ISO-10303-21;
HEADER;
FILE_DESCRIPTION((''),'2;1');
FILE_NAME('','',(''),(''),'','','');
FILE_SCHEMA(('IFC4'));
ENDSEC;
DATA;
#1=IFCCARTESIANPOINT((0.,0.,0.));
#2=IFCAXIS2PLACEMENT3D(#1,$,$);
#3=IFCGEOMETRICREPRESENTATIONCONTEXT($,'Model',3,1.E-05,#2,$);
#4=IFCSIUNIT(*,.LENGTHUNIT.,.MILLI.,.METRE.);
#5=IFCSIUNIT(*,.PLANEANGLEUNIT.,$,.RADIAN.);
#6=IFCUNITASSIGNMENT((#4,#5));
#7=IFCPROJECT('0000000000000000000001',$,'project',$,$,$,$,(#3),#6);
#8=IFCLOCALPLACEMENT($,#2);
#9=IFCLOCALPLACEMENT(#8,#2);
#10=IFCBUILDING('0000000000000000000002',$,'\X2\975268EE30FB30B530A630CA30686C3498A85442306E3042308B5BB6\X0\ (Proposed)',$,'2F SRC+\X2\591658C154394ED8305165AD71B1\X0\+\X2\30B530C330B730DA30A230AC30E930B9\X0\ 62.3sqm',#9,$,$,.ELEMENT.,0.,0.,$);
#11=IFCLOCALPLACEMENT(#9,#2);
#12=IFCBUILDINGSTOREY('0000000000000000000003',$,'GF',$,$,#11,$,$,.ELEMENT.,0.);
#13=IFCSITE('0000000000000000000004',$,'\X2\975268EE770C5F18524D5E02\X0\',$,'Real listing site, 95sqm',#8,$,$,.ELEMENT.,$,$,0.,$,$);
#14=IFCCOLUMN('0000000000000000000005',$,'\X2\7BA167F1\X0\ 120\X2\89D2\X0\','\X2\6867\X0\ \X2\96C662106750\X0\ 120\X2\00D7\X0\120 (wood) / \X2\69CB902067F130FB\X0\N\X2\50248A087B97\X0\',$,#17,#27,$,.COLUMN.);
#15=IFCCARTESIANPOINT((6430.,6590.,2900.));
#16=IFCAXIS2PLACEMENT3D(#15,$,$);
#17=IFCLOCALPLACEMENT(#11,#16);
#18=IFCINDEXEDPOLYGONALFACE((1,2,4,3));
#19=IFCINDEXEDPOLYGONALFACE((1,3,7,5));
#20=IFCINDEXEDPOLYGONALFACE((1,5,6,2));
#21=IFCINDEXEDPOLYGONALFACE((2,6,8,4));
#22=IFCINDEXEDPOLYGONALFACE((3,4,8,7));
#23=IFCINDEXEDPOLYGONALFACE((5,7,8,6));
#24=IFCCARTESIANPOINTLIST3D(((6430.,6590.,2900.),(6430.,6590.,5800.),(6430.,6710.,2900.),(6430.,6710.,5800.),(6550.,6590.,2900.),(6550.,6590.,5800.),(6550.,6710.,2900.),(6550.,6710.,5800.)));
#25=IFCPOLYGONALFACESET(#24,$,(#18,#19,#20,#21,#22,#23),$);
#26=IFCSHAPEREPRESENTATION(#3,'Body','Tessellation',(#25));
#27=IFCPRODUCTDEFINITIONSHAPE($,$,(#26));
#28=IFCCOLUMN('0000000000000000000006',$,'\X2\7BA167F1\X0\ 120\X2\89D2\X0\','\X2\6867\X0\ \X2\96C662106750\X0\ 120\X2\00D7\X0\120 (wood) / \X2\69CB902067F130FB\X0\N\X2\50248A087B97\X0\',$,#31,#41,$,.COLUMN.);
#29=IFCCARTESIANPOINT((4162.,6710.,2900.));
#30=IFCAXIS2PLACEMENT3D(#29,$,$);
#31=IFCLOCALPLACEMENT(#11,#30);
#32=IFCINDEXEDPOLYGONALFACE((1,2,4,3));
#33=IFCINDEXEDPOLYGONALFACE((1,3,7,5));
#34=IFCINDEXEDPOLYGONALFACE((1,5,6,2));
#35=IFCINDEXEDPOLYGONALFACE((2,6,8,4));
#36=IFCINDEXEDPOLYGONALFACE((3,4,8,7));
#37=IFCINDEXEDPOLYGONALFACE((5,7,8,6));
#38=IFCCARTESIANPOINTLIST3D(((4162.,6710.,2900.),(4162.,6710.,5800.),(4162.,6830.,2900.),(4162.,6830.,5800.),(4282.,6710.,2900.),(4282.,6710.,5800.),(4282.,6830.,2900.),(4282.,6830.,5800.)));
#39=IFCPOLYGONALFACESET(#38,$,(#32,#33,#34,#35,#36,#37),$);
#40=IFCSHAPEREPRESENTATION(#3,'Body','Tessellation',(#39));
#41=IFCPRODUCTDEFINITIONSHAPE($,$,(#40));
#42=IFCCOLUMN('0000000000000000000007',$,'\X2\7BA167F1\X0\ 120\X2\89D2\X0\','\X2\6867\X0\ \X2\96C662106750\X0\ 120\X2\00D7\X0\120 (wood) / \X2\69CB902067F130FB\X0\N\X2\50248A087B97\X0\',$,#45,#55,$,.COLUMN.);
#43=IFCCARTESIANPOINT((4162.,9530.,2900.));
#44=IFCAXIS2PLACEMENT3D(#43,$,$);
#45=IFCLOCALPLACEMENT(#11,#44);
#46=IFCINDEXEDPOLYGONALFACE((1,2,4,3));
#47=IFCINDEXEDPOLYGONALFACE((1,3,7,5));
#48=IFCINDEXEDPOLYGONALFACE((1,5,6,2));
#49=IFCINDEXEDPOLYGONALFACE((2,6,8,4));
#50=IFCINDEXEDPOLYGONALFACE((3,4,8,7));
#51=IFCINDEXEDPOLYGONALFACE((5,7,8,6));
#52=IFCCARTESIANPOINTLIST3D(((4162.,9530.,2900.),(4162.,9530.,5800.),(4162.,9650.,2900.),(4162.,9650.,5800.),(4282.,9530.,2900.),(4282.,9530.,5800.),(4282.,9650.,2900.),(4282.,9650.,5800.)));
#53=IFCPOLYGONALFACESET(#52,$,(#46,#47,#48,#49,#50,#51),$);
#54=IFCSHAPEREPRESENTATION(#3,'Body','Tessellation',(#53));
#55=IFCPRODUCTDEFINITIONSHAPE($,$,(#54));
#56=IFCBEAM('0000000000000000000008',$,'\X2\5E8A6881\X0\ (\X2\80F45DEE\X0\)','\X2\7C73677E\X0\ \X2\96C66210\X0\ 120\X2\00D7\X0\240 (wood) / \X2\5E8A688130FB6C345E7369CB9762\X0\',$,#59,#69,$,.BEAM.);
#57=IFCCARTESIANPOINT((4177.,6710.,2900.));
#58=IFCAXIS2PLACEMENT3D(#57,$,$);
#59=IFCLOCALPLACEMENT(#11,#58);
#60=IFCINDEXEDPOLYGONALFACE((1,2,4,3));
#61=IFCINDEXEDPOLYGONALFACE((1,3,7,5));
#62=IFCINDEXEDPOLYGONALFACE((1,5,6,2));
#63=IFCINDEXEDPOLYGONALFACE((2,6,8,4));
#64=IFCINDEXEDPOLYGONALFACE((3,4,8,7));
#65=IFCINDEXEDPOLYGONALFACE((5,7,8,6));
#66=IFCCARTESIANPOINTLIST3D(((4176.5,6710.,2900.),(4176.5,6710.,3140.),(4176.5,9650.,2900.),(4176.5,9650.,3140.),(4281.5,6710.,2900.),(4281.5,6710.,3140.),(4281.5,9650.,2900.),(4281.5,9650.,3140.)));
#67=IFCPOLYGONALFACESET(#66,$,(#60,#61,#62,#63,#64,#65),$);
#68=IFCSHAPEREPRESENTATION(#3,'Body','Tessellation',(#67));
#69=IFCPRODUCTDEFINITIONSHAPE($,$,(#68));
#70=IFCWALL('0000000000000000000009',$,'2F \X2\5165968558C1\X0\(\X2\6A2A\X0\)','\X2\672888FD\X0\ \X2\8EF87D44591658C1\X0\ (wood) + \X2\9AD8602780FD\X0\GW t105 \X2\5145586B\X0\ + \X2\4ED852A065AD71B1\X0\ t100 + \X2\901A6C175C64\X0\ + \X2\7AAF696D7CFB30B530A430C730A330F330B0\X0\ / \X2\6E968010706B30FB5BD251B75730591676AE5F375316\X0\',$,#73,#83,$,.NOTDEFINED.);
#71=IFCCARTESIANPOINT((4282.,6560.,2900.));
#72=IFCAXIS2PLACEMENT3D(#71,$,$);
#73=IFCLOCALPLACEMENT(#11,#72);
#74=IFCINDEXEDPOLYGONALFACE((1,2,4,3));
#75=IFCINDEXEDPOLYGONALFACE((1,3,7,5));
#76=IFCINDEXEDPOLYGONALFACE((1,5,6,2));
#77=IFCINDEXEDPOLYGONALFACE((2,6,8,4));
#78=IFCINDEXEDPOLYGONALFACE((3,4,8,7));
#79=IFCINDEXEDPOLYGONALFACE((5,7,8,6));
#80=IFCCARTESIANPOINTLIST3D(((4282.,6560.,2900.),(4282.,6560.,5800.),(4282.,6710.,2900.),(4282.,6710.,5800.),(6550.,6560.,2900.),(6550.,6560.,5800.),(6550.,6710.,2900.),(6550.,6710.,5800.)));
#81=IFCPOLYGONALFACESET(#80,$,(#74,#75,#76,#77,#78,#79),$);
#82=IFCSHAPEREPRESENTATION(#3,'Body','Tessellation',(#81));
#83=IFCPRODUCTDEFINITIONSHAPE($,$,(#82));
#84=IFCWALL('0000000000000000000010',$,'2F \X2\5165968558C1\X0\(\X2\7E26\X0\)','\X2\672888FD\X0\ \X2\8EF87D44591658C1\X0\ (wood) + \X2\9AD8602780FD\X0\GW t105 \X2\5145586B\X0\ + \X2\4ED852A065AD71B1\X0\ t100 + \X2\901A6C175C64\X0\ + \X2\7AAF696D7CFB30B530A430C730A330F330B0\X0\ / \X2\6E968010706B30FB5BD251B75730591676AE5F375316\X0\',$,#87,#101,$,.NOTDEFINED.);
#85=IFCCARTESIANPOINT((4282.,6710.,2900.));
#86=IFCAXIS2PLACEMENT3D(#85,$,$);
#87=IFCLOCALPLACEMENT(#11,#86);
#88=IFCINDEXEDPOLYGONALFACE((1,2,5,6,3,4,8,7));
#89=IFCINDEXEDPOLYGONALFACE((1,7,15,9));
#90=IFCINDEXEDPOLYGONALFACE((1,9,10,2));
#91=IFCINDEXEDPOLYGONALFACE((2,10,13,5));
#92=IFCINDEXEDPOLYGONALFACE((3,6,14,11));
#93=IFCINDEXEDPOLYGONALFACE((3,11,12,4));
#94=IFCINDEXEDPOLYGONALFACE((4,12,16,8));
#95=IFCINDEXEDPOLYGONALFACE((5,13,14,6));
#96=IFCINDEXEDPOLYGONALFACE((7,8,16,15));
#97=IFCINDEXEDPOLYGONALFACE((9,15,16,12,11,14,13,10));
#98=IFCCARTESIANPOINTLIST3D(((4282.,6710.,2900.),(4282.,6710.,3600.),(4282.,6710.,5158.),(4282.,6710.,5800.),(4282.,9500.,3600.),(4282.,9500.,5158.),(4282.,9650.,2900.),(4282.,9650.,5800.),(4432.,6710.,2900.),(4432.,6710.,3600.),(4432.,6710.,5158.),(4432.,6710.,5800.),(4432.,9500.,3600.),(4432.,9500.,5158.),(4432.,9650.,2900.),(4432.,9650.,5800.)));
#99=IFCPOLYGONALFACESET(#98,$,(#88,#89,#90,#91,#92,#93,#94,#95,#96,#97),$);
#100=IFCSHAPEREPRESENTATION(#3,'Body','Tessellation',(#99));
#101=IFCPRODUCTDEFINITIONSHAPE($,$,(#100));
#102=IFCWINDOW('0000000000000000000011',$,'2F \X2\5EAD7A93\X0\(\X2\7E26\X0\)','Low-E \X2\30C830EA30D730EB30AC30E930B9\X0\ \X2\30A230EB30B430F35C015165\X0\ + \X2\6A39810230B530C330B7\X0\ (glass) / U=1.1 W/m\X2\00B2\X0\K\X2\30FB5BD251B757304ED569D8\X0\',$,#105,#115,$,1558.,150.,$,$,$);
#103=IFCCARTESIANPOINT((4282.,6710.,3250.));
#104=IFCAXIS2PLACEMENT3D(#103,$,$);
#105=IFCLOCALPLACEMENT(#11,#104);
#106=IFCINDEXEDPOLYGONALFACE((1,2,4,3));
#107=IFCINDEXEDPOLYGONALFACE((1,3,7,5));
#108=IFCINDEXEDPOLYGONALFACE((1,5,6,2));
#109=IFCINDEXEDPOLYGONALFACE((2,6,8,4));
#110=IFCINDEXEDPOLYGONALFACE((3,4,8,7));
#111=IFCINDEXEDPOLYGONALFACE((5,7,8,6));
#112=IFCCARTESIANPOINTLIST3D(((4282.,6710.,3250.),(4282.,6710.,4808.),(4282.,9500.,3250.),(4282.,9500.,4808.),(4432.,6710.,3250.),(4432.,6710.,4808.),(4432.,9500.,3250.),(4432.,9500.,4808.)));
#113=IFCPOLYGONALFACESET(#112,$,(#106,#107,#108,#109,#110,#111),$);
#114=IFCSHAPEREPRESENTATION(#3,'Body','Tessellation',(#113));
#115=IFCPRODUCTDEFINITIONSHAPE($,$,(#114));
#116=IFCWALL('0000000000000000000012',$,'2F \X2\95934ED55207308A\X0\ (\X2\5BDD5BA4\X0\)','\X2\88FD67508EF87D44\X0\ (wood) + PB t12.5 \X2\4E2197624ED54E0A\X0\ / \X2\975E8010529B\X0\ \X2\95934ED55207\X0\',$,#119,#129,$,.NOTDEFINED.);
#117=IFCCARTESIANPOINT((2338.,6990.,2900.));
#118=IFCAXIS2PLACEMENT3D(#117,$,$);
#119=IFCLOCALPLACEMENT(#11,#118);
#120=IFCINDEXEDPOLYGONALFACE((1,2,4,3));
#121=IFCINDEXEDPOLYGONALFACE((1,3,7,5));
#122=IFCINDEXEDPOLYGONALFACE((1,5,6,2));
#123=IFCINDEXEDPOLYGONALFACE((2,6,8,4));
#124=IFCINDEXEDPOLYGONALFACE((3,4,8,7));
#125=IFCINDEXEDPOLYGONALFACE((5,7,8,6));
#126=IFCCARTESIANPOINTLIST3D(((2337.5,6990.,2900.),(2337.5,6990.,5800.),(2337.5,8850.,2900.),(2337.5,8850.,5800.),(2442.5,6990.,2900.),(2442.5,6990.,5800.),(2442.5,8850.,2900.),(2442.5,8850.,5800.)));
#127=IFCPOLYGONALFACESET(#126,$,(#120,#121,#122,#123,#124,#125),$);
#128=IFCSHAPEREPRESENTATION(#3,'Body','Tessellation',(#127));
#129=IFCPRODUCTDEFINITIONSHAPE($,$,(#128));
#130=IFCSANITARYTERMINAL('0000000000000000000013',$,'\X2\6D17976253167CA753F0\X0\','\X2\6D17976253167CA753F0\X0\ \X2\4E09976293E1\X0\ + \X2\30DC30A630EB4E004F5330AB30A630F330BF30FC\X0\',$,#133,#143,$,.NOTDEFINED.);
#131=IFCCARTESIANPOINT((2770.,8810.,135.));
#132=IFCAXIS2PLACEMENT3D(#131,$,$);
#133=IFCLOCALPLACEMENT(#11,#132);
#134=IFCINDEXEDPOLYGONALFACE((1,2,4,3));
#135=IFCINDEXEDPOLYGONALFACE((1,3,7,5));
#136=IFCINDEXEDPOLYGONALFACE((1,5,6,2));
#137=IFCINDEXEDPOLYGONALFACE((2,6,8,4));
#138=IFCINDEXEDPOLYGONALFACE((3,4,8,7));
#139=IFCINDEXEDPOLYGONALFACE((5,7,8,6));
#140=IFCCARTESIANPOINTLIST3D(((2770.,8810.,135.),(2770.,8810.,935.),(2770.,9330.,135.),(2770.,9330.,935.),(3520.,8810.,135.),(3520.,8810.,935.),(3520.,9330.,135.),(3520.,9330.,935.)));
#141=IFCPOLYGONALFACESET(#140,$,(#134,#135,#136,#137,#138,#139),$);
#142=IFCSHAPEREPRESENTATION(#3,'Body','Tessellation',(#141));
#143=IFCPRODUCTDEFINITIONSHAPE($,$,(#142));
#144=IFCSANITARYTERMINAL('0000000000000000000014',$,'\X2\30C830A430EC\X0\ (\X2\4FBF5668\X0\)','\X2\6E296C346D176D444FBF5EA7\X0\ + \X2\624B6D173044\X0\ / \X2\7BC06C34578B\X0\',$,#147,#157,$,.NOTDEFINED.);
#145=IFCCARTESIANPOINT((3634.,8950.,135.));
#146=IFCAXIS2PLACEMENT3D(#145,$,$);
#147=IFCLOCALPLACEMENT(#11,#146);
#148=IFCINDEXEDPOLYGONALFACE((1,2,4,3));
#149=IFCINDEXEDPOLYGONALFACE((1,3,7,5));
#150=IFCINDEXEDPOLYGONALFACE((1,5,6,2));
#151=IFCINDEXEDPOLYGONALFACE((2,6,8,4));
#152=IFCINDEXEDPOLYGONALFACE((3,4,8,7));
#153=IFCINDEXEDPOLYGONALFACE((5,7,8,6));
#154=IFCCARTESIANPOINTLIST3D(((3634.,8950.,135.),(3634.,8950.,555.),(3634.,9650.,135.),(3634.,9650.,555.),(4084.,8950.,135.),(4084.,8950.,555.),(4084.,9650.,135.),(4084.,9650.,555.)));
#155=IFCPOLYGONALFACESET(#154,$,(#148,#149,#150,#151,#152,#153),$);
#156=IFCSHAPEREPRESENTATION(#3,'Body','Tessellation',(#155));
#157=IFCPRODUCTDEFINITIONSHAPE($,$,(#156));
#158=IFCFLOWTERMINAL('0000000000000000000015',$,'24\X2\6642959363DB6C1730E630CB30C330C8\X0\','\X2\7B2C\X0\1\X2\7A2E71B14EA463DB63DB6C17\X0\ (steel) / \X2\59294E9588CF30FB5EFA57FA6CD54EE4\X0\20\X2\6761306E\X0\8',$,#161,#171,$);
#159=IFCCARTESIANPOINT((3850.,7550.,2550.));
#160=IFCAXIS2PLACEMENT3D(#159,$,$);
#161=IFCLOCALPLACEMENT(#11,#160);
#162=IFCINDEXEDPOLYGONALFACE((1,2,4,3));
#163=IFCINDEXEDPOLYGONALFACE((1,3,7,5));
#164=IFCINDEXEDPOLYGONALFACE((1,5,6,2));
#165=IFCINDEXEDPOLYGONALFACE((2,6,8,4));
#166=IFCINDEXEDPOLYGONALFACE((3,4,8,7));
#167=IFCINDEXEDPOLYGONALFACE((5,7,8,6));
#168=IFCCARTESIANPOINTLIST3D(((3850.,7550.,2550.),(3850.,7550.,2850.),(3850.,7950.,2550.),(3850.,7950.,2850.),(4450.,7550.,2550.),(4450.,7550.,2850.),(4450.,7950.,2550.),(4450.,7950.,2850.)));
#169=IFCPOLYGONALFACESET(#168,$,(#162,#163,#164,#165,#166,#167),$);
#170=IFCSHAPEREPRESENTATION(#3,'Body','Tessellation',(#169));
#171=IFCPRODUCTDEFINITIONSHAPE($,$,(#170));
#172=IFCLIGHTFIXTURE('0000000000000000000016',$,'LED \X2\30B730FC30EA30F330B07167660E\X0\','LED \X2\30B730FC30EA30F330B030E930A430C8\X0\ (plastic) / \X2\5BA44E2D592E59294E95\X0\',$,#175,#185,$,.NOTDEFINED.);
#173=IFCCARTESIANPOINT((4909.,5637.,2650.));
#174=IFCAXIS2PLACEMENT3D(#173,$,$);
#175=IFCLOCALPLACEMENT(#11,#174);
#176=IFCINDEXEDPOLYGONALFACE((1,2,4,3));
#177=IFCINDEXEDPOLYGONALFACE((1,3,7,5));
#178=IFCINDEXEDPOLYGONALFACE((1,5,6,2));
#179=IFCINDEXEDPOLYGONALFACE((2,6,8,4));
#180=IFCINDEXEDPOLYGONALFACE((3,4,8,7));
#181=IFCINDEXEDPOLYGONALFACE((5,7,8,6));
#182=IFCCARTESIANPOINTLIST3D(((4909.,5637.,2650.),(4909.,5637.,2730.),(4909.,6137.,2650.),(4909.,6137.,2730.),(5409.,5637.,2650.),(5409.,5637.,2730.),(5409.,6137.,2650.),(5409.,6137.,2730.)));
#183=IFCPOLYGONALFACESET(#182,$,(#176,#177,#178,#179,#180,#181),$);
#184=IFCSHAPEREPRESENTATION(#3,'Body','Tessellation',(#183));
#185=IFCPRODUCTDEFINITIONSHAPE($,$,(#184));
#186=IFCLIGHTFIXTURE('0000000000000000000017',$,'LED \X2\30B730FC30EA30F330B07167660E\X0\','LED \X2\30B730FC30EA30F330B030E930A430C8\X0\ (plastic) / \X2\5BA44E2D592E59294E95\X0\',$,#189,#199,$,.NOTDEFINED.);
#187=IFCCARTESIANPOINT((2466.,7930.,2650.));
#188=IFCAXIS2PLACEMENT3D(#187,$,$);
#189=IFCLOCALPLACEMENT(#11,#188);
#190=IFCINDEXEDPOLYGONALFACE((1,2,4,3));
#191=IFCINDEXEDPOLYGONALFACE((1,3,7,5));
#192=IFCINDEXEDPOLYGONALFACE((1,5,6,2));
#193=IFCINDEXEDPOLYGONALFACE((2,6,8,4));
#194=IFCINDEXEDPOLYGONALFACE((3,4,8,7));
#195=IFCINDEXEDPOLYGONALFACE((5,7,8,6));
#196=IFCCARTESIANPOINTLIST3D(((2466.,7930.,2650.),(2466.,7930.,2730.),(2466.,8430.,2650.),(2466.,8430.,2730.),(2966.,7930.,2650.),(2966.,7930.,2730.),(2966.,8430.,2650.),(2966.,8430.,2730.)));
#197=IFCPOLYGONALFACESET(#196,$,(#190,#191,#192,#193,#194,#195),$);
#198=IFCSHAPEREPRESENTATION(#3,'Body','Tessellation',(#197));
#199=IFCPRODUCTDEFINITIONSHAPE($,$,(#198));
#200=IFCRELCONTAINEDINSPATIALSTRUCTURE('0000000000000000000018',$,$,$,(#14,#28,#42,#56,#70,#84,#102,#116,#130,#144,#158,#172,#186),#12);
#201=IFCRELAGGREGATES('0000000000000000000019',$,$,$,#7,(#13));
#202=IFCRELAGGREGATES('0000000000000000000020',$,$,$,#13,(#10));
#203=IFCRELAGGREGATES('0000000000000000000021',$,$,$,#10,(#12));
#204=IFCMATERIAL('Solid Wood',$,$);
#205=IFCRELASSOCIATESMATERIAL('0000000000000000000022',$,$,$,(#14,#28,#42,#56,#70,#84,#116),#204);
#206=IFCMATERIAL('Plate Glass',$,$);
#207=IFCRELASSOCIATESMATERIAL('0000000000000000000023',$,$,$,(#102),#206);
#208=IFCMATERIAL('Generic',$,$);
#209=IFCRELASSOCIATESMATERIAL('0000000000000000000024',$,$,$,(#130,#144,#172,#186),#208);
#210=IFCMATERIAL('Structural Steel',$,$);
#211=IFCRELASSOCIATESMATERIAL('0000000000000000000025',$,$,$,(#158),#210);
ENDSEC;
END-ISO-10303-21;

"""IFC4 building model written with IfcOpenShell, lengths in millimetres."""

from ifc_helpers import new_model, si_unit, frame, frame_2d, origin, place, context, project, spatial, rectangle, extrude, material, element, fill, save


model = new_model("IFC4")

# Units and contexts
model_context = context("Model", 3, precision=1e-05, world=origin())
ifc_project = project(units=[si_unit("LENGTHUNIT", "METRE", prefix="MILLI"), si_unit("PLANEANGLEUNIT", "RADIAN")], contexts=[model_context])

# Site, building, storey
site_placement = place(None, origin())
site = spatial("IfcSite", under=ifc_project, at=site_placement, Name="青森県弘前市", ObjectType="Real listing site, 95sqm", CompositionType="ELEMENT", RefElevation=0.0)
building_placement = place(site_placement, origin())
building = spatial("IfcBuilding", under=site, at=building_placement, Name="青森・サウナと水風呂のある家 (Proposed)", ObjectType="2F SRC+外壁吹付け断熱+サッシペアガラス 62.3sqm", CompositionType="ELEMENT", ElevationOfRefHeight=0.0, ElevationOfTerrain=0.0)
storey_placement = place(building_placement, origin())
storey = spatial("IfcBuildingStorey", under=building, at=storey_placement, Name="GF", CompositionType="ELEMENT", Elevation=0.0)

# Columns
ifc_material_1 = material(Name="Solid Wood")
column_1_placement = place(storey_placement, frame((6430.0, 6590.0, 2900.0)))
element("IfcColumn", 1, at=column_1_placement, inside=storey, material=ifc_material_1, Name="管柱 120角", Description="桧 集成材 120×120 (wood) / 構造柱・N値計算", PredefinedType="COLUMN", context=model_context, shape_type="SweptSolid", body=[
    extrude(rectangle(XDim=120.0, YDim=120.0, at=frame_2d((60.0, 60.0))), frame((6430.0, 6590.0, 2900.0)), (0.0, 0.0, 1.0), 2900.0),
])
column_2_placement = place(storey_placement, frame((4162.0, 6710.0, 2900.0)))
element("IfcColumn", 2, at=column_2_placement, inside=storey, material=ifc_material_1, Name="管柱 120角", Description="桧 集成材 120×120 (wood) / 構造柱・N値計算", PredefinedType="COLUMN", context=model_context, shape_type="SweptSolid", body=[
    extrude(rectangle(XDim=120.0, YDim=120.0, at=frame_2d((60.0, 60.0))), frame((4162.0, 6710.0, 2900.0)), (0.0, 0.0, 1.0), 2900.0),
])
column_3_placement = place(storey_placement, frame((4162.0, 9530.0, 2900.0)))
element("IfcColumn", 3, at=column_3_placement, inside=storey, material=ifc_material_1, Name="管柱 120角", Description="桧 集成材 120×120 (wood) / 構造柱・N値計算", PredefinedType="COLUMN", context=model_context, shape_type="SweptSolid", body=[
    extrude(rectangle(XDim=120.0, YDim=120.0, at=frame_2d((60.0, 60.0))), frame((4162.0, 9530.0, 2900.0)), (0.0, 0.0, 1.0), 2900.0),
])

# Beam
beam_placement = place(storey_placement, frame((4177.0, 6710.0, 2900.0)))
element("IfcBeam", 4, at=beam_placement, inside=storey, material=ifc_material_1, Name="床梁 (胴差)", Description="米松 集成 120×240 (wood) / 床梁・水平構面", PredefinedType="BEAM", context=model_context, shape_type="SweptSolid", body=[
    extrude(rectangle(XDim=105.0, YDim=2940.0, at=frame_2d((52.0, 1470.0))), frame((4177.0, 6710.0, 2900.0)), (0.0, 0.0, 1.0), 240.0),
])

# Wall
wall_1_placement = place(storey_placement, frame((4282.0, 6560.0, 2900.0)))
element("IfcWall", 5, at=wall_1_placement, inside=storey, material=ifc_material_1, Name="2F 入隅壁(横)", Description="木製 軸組外壁 (wood) + 高性能GW t105 充填 + 付加断熱 t100 + 通気層 + 窯業系サイディング / 準耐火・寒冷地外皮強化", PredefinedType="NOTDEFINED", context=model_context, shape_type="SweptSolid", body=[
    extrude(rectangle(XDim=2268.0, YDim=150.0, at=frame_2d((1134.0, 75.0))), frame((4282.0, 6560.0, 2900.0)), (0.0, 0.0, 1.0), 2900.0),
])

# Wall, opening, window
wall_2_placement = place(storey_placement, frame((4282.0, 6710.0, 2900.0)))
wall_2 = element("IfcWall", 6, at=wall_2_placement, inside=storey, material=ifc_material_1, Name="2F 入隅壁(縦)", Description="木製 軸組外壁 (wood) + 高性能GW t105 充填 + 付加断熱 t100 + 通気層 + 窯業系サイディング / 準耐火・寒冷地外皮強化", PredefinedType="NOTDEFINED", context=model_context, shape_type="SweptSolid", body=[
    extrude(rectangle(XDim=150.0, YDim=2940.0, at=frame_2d((75.0, 1470.0))), frame((4282.0, 6710.0, 2900.0)), (0.0, 0.0, 1.0), 2900.0),
])
opening_placement = place(storey_placement, frame((4282.0, 6710.0, 3250.0)))
opening = element("IfcOpeningElement", 7, at=opening_placement, cuts=wall_2, PredefinedType="NOTDEFINED", context=model_context, shape_type="SweptSolid", body=[
    extrude(rectangle(XDim=150.0, YDim=2790.0, at=frame_2d((75.0, 1395.0))), frame((4282.0, 6710.0, 3250.0)), (0.0, 0.0, 1.0), 1558.0),
])
ifc_material_2 = material(Name="Plate Glass")
window_placement = place(storey_placement, frame((4282.0, 6710.0, 3250.0)))
window = element("IfcWindow", 8, at=window_placement, inside=storey, material=ifc_material_2, Name="2F 庭窓(縦)", Description="Low-E トリプルガラス アルゴン封入 + 樹脂サッシ (glass) / U=1.1 W/m²K・寒冷地仕様", OverallHeight=1558.0, OverallWidth=150.0, context=model_context, shape_type="SweptSolid", body=[
    extrude(rectangle(XDim=150.0, YDim=2790.0, at=frame_2d((75.0, 1395.0))), frame((4282.0, 6710.0, 3250.0)), (0.0, 0.0, 1.0), 1558.0),
])
fill(opening, window)

# Wall
wall_3_placement = place(storey_placement, frame((2338.0, 6990.0, 2900.0)))
element("IfcWall", 9, at=wall_3_placement, inside=storey, material=ifc_material_1, Name="2F 間仕切り (寝室)", Description="製材軸組 (wood) + PB t12.5 両面仕上 / 非耐力 間仕切", PredefinedType="NOTDEFINED", context=model_context, shape_type="SweptSolid", body=[
    extrude(rectangle(XDim=105.0, YDim=1860.0, at=frame_2d((52.0, 930.0))), frame((2338.0, 6990.0, 2900.0)), (0.0, 0.0, 1.0), 2900.0),
])

# Sanitary terminals
ifc_material_3 = material(Name="Generic")
sanitary_terminal_1_placement = place(storey_placement, frame((2770.0, 8810.0, 135.0)))
element("IfcSanitaryTerminal", 10, at=sanitary_terminal_1_placement, inside=storey, material=ifc_material_3, Name="洗面化粧台", Description="洗面化粧台 三面鏡 + ボウル一体カウンター", PredefinedType="NOTDEFINED", context=model_context, shape_type="SweptSolid", body=[
    extrude(rectangle(XDim=750.0, YDim=520.0, at=frame_2d((375.0, 260.0))), frame((2770.0, 8810.0, 135.0)), (0.0, 0.0, 1.0), 800.0),
])
sanitary_terminal_2_placement = place(storey_placement, frame((3634.0, 8950.0, 135.0)))
element("IfcSanitaryTerminal", 11, at=sanitary_terminal_2_placement, inside=storey, material=ifc_material_3, Name="トイレ (便器)", Description="温水洗浄便座 + 手洗い / 節水型", PredefinedType="NOTDEFINED", context=model_context, shape_type="SweptSolid", body=[
    extrude(rectangle(XDim=450.0, YDim=700.0, at=frame_2d((225.0, 350.0))), frame((3634.0, 8950.0, 135.0)), (0.0, 0.0, 1.0), 420.0),
])

# Flow terminal
ifc_material_4 = material(Name="Structural Steel")
flow_terminal_placement = place(storey_placement, frame((3850.0, 7550.0, 2550.0)))
element("IfcFlowTerminal", 12, at=flow_terminal_placement, inside=storey, material=ifc_material_4, Name="24時間換気ユニット", Description="第1種熱交換換気 (steel) / 天井裏・建基法令20条の8", context=model_context, shape_type="SweptSolid", body=[
    extrude(rectangle(XDim=600.0, YDim=400.0, at=frame_2d((300.0, 200.0))), frame((3850.0, 7550.0, 2550.0)), (0.0, 0.0, 1.0), 300.0),
])

# Light fixtures
light_fixture_1_placement = place(storey_placement, frame((4909.0, 5637.0, 2650.0)))
element("IfcLightFixture", 13, at=light_fixture_1_placement, inside=storey, material=ifc_material_3, Name="LED シーリング照明", Description="LED シーリングライト (plastic) / 室中央天井", PredefinedType="NOTDEFINED", context=model_context, shape_type="SweptSolid", body=[
    extrude(rectangle(XDim=500.0, YDim=500.0, at=frame_2d((250.0, 250.0))), frame((4909.0, 5637.0, 2650.0)), (0.0, 0.0, 1.0), 80.0),
])
light_fixture_2_placement = place(storey_placement, frame((2466.0, 7930.0, 2650.0)))
element("IfcLightFixture", 14, at=light_fixture_2_placement, inside=storey, material=ifc_material_3, Name="LED シーリング照明", Description="LED シーリングライト (plastic) / 室中央天井", PredefinedType="NOTDEFINED", context=model_context, shape_type="SweptSolid", body=[
    extrude(rectangle(XDim=500.0, YDim=500.0, at=frame_2d((250.0, 250.0))), frame((2466.0, 7930.0, 2650.0)), (0.0, 0.0, 1.0), 80.0),
])

save(model, "model.ifc")
